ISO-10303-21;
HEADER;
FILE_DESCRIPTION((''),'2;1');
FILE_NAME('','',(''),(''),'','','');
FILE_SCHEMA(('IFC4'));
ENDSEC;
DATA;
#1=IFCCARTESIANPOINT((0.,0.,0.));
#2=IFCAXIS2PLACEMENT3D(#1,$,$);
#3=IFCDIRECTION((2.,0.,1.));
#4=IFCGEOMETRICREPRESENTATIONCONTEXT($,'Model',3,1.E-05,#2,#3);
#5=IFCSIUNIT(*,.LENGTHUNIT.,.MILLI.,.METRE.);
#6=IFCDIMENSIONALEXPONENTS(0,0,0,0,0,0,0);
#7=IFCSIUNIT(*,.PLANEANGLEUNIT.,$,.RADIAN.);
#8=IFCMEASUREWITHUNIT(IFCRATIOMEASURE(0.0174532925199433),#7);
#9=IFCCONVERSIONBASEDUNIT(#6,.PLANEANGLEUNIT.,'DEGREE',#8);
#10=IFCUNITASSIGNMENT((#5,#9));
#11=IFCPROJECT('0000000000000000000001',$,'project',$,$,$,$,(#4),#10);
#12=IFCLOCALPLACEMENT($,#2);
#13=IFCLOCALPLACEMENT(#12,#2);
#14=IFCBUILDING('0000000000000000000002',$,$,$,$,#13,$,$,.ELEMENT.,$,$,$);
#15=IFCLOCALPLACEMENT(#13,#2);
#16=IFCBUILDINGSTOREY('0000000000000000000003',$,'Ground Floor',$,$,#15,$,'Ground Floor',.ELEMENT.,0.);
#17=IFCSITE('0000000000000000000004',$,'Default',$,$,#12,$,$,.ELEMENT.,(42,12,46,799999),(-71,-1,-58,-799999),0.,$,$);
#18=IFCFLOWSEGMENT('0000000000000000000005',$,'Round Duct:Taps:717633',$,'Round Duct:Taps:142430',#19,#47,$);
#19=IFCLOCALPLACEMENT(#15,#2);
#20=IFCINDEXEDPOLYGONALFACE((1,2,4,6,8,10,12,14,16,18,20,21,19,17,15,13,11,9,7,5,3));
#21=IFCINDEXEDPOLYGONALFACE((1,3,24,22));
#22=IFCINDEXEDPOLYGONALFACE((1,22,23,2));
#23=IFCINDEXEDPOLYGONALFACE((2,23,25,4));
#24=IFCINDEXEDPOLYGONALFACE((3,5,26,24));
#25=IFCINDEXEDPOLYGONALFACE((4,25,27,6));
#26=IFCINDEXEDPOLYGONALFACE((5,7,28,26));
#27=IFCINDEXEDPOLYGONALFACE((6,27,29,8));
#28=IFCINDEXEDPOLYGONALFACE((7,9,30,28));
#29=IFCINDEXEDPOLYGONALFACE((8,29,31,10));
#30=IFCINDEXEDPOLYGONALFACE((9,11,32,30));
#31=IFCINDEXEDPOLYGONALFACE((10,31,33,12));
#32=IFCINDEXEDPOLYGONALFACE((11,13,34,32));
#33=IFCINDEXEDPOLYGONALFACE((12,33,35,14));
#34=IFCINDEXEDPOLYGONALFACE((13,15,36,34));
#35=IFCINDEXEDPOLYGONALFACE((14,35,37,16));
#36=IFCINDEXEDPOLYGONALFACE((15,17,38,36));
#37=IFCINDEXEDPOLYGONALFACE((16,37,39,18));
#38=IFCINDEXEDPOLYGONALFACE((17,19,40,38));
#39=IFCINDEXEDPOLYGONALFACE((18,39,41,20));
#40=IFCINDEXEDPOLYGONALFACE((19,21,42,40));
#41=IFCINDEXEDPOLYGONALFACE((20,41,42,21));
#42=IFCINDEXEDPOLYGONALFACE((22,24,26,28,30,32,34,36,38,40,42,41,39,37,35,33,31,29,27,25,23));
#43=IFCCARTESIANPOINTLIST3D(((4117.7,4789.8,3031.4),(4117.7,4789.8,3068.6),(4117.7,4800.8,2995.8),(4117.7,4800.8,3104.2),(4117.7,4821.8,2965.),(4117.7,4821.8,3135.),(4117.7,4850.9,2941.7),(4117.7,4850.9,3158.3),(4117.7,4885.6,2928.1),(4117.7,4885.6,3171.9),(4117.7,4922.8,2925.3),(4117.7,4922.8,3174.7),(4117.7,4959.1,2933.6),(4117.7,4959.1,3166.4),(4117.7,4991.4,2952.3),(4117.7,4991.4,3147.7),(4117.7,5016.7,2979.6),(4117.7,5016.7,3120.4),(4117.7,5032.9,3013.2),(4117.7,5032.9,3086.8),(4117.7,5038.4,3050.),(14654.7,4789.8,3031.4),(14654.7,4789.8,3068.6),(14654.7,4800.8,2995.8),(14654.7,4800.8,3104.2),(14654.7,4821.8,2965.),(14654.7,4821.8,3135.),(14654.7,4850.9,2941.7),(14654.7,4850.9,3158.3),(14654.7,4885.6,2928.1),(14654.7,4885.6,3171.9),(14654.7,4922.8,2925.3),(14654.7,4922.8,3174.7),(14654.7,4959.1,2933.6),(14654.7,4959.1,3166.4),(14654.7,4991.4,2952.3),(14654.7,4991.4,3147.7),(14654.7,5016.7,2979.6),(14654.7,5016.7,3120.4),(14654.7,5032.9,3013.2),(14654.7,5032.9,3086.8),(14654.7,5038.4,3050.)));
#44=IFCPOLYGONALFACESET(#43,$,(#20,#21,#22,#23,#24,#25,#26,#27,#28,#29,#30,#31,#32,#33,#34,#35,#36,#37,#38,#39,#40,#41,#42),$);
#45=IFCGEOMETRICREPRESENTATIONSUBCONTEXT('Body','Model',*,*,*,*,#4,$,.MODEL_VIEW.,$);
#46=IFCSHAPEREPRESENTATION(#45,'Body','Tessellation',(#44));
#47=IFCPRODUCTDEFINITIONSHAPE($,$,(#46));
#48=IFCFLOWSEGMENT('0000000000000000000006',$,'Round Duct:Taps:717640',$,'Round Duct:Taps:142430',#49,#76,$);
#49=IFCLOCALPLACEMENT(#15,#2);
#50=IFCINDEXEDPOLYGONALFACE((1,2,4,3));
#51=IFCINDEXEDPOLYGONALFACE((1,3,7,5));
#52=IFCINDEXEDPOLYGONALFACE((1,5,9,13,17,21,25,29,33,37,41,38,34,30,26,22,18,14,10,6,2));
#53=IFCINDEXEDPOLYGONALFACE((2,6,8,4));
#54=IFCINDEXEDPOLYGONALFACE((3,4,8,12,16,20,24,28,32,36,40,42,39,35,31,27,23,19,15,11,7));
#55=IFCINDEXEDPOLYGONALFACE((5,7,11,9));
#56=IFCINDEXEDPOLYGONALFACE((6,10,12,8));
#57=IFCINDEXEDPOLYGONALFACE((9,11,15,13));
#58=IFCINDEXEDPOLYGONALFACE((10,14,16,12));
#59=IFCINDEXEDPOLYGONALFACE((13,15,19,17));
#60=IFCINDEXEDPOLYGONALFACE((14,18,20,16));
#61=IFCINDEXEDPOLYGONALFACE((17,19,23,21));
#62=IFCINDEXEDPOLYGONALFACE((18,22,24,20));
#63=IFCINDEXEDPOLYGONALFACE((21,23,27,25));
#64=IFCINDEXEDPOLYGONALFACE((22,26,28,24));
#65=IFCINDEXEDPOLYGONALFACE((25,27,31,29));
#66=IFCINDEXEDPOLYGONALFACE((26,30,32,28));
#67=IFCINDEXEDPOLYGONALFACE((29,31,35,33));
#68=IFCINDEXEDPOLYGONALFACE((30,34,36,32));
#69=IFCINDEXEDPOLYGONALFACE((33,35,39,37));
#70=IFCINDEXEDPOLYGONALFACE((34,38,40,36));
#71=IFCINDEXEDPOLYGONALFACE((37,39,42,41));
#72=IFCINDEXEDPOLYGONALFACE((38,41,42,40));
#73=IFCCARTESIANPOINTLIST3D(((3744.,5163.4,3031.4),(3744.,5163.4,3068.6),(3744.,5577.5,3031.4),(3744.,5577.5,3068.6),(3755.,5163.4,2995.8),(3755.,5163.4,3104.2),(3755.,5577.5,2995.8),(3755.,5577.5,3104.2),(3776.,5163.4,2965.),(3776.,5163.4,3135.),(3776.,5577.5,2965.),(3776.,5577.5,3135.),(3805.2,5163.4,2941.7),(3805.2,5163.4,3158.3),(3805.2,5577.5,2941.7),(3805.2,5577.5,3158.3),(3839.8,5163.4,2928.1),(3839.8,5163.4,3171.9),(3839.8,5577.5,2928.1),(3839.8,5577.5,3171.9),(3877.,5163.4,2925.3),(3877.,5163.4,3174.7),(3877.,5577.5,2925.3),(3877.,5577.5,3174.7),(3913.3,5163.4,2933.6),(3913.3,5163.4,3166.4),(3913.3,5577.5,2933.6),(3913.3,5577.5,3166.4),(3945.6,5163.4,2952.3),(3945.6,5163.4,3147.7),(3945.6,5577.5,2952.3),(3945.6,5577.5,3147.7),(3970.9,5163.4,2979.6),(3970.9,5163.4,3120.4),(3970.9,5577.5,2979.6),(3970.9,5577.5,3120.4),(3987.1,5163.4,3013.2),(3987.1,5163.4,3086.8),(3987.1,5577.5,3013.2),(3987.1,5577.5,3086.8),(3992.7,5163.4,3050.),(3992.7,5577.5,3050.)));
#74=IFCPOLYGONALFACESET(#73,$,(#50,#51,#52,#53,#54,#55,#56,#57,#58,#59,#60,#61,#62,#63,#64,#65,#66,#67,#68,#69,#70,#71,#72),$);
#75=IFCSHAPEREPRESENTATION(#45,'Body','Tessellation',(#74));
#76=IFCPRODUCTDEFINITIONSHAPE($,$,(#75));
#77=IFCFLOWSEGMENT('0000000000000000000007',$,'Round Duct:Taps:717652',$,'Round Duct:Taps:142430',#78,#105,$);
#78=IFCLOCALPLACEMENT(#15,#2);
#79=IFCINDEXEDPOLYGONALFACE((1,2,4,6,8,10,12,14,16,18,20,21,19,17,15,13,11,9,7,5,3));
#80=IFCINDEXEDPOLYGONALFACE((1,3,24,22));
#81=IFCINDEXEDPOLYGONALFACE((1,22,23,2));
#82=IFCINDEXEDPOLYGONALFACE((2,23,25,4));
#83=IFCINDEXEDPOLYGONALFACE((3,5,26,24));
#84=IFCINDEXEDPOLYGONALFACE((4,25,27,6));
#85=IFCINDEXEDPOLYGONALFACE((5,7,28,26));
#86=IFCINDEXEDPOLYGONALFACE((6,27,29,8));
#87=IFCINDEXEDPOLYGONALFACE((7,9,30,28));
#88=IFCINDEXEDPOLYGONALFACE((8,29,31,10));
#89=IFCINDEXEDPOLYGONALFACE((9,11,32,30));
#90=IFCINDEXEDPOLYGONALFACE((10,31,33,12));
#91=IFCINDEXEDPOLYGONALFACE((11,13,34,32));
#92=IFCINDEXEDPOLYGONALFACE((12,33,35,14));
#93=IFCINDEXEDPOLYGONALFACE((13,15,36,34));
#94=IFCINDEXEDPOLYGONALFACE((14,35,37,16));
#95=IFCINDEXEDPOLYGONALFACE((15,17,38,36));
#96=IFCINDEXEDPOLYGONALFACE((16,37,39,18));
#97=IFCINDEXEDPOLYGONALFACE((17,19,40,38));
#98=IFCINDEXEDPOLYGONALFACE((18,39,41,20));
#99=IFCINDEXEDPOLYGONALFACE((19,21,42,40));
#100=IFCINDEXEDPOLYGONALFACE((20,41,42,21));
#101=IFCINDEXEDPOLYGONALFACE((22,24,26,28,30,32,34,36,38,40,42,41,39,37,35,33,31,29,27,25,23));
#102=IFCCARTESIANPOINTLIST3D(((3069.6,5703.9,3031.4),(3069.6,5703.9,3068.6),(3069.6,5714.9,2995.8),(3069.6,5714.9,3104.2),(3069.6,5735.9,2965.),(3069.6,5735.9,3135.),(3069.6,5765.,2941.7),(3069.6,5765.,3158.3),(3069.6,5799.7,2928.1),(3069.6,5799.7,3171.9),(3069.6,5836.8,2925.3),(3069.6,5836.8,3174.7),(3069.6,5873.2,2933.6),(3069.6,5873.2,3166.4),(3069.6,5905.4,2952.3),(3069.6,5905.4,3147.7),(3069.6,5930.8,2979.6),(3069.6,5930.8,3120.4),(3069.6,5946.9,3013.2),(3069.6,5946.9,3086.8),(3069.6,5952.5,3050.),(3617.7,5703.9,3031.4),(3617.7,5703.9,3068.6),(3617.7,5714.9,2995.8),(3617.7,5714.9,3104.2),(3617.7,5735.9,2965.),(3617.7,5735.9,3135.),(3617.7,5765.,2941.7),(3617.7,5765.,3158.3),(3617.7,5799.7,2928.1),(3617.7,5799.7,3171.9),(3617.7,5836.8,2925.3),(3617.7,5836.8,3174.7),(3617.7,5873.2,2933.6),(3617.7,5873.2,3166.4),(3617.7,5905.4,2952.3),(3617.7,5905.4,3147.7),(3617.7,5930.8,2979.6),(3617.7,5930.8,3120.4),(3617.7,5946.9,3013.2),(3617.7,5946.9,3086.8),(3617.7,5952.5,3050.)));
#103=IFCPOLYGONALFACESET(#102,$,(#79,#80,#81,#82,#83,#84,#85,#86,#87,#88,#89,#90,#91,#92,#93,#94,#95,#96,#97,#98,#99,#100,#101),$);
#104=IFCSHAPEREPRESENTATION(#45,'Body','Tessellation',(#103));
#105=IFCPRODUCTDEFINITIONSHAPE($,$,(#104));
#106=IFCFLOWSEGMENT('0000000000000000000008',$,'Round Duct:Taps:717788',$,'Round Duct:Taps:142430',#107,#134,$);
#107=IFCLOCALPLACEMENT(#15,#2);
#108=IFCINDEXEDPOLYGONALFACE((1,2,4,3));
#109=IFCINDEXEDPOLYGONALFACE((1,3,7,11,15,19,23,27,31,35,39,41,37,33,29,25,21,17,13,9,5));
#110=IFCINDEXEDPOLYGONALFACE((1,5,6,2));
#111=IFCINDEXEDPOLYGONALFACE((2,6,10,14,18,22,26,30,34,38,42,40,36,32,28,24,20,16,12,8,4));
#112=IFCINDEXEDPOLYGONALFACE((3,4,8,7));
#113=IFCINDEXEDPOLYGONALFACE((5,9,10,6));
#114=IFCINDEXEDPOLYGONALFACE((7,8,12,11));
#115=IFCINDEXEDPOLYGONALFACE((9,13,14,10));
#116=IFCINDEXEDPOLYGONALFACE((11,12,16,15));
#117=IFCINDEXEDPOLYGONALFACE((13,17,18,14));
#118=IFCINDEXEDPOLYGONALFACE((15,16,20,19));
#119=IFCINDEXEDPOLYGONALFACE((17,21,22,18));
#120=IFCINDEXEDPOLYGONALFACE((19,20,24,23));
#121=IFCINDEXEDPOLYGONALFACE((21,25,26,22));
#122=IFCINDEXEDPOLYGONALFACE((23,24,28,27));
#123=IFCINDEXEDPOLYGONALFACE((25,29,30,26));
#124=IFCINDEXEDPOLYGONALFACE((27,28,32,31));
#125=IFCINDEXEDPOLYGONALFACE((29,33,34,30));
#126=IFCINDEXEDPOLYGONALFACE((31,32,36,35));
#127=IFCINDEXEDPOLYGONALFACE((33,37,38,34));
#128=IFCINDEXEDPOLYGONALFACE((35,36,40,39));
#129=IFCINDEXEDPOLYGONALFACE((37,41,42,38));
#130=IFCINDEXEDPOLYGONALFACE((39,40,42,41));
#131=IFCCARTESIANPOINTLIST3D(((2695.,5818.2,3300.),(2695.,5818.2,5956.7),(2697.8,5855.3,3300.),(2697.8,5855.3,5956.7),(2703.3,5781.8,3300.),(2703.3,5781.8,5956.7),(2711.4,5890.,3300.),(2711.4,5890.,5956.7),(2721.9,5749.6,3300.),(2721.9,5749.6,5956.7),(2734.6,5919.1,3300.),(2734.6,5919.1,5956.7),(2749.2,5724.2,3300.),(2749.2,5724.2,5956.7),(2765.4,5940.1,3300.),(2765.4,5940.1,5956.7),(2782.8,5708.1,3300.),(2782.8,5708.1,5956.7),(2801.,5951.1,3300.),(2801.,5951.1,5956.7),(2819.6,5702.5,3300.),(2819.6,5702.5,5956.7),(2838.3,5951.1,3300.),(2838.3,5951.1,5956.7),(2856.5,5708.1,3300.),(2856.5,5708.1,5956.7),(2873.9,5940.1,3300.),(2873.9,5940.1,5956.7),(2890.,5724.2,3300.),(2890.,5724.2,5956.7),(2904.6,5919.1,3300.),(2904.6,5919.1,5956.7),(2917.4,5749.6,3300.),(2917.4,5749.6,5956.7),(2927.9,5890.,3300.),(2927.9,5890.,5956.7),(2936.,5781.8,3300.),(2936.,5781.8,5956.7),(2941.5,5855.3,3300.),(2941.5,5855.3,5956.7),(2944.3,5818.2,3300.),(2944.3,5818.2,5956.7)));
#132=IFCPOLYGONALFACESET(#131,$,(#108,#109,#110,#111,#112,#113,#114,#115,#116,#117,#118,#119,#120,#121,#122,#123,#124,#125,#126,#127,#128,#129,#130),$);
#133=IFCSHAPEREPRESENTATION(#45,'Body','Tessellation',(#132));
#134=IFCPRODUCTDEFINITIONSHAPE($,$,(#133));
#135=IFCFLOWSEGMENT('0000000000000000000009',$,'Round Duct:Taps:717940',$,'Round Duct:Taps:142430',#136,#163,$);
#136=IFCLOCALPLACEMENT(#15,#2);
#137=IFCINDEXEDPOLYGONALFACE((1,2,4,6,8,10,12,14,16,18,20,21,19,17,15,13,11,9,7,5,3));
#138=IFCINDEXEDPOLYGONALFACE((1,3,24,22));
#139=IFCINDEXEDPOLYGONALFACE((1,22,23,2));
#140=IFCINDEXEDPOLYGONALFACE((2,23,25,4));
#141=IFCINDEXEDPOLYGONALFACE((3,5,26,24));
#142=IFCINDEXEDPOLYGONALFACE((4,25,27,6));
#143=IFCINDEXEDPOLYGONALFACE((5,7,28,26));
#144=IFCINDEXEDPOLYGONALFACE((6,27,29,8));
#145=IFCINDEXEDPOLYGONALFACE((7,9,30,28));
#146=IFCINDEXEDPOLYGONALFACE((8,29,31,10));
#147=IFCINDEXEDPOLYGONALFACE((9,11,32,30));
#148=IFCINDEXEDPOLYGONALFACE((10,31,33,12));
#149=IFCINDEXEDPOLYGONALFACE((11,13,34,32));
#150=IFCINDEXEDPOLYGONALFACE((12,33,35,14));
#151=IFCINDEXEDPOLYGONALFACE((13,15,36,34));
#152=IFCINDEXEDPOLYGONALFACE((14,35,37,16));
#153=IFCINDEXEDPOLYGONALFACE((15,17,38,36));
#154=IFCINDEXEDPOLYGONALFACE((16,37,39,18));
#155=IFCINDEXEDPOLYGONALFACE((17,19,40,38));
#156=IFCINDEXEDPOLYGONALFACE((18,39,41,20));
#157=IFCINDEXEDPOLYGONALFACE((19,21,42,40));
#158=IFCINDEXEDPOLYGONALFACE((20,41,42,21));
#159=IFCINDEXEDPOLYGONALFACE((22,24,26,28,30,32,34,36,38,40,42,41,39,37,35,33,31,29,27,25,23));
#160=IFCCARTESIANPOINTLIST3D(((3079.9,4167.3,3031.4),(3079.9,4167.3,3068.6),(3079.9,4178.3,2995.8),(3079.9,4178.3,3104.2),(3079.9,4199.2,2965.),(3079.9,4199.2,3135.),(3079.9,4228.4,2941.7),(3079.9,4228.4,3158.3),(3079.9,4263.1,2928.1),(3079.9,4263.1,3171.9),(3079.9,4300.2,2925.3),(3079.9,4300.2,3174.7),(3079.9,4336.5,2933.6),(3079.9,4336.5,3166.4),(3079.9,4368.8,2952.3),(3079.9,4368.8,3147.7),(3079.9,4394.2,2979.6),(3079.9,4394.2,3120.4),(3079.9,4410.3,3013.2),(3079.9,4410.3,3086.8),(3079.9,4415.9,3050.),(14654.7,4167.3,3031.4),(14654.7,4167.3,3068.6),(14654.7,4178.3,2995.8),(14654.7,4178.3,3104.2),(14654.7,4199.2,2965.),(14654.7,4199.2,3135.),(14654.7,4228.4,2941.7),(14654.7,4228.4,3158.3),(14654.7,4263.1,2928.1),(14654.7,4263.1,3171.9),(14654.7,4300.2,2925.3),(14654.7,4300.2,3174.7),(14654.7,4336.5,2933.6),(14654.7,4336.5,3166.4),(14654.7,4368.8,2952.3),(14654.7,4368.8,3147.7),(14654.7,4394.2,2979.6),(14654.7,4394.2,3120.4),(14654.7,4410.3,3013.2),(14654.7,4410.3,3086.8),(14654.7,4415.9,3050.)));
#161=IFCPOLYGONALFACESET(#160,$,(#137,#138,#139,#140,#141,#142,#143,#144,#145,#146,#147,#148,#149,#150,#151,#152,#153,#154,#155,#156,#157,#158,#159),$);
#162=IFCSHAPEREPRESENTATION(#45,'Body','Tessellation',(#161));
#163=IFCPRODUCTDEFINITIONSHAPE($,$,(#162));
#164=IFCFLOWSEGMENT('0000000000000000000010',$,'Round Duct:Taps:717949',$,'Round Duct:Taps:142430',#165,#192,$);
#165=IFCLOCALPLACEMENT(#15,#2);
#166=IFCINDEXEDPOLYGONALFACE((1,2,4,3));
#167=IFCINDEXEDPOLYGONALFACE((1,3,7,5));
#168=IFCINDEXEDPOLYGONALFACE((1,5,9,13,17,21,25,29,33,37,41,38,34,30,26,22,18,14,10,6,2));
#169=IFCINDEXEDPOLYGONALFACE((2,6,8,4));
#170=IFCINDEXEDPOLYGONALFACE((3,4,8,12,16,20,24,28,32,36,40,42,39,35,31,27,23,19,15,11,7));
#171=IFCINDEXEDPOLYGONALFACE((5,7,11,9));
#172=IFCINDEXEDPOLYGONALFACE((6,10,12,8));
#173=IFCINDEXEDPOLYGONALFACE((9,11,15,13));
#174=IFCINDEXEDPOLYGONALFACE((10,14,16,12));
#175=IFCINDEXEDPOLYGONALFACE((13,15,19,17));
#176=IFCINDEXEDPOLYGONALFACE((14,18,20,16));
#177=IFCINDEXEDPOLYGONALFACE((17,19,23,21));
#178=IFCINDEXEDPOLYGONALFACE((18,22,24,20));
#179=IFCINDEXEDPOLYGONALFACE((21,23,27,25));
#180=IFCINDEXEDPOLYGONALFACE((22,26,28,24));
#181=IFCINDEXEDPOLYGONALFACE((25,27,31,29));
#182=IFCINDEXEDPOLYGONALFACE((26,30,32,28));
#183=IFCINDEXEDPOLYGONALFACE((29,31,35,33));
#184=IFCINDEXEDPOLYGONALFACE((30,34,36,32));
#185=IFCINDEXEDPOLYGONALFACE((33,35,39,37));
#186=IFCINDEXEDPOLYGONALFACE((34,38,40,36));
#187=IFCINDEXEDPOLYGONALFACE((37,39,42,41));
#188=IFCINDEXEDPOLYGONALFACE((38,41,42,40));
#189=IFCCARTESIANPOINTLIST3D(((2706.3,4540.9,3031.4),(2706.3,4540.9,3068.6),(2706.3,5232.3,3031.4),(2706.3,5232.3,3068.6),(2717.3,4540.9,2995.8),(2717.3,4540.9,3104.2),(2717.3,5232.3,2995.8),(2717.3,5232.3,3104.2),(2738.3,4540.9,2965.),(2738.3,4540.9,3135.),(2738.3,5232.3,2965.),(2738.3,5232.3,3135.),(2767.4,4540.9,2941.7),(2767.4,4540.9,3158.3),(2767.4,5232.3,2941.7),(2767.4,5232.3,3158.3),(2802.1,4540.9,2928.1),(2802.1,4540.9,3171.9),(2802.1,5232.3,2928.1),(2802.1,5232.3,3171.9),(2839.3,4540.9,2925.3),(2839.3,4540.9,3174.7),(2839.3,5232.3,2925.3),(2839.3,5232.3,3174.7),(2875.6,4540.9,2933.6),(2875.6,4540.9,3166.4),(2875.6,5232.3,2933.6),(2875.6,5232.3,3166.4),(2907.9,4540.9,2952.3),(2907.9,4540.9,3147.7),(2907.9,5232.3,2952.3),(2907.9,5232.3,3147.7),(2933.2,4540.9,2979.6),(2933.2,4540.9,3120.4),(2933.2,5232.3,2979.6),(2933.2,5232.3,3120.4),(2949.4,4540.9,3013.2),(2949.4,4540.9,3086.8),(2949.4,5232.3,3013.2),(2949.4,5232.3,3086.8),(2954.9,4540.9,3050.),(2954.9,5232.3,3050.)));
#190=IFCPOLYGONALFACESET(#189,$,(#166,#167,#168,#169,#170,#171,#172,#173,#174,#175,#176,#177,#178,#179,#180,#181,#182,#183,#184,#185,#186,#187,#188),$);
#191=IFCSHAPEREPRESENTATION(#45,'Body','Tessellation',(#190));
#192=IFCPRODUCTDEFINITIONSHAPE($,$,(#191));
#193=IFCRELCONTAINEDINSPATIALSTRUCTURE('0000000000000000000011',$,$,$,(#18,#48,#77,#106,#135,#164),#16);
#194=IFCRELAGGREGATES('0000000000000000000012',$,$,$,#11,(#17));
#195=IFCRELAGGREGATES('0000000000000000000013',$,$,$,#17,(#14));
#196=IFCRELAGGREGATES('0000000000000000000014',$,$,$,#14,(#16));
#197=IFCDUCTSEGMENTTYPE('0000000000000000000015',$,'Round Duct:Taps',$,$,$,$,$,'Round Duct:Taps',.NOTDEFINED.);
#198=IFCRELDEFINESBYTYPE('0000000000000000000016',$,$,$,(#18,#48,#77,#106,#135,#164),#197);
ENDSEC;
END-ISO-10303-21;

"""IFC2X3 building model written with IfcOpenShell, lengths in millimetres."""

from ifc_helpers import new_model, entity, si_unit, converted_unit, direction, frame, frame_2d, origin, origin_2d_with_axis, place, context, subcontext, project, spatial, circle, extrude, type_object, element, save


model = new_model("IFC2X3")

# Units and contexts
model_context = context("Model", 3, precision=1e-05, world=origin(), true_north=direction((2.0, 0.0, 1.0)))
body_context = subcontext(model_context, "Body", "Model", "MODEL_VIEW")
ifc_project = project(units=[si_unit("LENGTHUNIT", "METRE", prefix="MILLI"), converted_unit("PLANEANGLEUNIT", "DEGREE", entity("IfcRatioMeasure", 0.0174532925199433), si_unit("PLANEANGLEUNIT", "RADIAN"), dimensions=[0, 0, 0, 0, 0, 0, 0])], contexts=[model_context])

# Site, building, storey
site_placement = place(None, origin())
site = spatial("IfcSite", under=ifc_project, at=site_placement, Name="Default", CompositionType="ELEMENT", RefLatitude=(42, 12, 46, 799999), RefLongitude=(-71, -1, -58, -799999), RefElevation=0.0)
building_placement = place(site_placement, origin())
building = spatial("IfcBuilding", under=site, at=building_placement, CompositionType="ELEMENT")
storey_placement = place(building_placement, origin())
storey = spatial("IfcBuildingStorey", under=building, at=storey_placement, Name="Ground Floor", LongName="Ground Floor", CompositionType="ELEMENT", Elevation=0.0)

# Flow segments
duct_segment_type_1 = type_object("IfcDuctSegmentType", Name="Round Duct:Taps", ElementType="Round Duct:Taps", PredefinedType="NOTDEFINED")
flow_segment_1_placement = place(storey_placement, origin())
element("IfcFlowSegment", 1, at=flow_segment_1_placement, inside=storey, type_object=duct_segment_type_1, Name="Round Duct:Taps:717633", ObjectType="Round Duct:Taps:142430", context=body_context, shape_type="SweptSolid", body=[
    extrude(circle(Radius=125.0, at=frame_2d((0.0, 0.0), x_axis=(1.0, 0.0))), frame((4117.7, 4913.4, 3050.0), z_axis=(1.0, 0.0, 0.0), x_axis=(0.0, 1.0, 0.0)), (0.0, 0.0, 1.0), 10537.0),
])
flow_segment_2_placement = place(storey_placement, origin())
element("IfcFlowSegment", 2, at=flow_segment_2_placement, inside=storey, type_object=duct_segment_type_1, Name="Round Duct:Taps:717640", ObjectType="Round Duct:Taps:142430", context=body_context, shape_type="SweptSolid", body=[
    extrude(circle(Radius=125.0, at=frame_2d((0.0, 0.0), x_axis=(1.0, 0.0))), frame((3867.7, 5163.4, 3050.0), z_axis=(0.0, 1.0, 0.0), x_axis=(1.0, 0.0, 0.0)), (0.0, 0.0, 1.0), 414.1),
])
flow_segment_3_placement = place(storey_placement, origin())
element("IfcFlowSegment", 3, at=flow_segment_3_placement, inside=storey, type_object=duct_segment_type_1, Name="Round Duct:Taps:717652", ObjectType="Round Duct:Taps:142430", context=body_context, shape_type="SweptSolid", body=[
    extrude(circle(Radius=125.0, at=frame_2d((0.0, 0.0), x_axis=(1.0, 0.0))), frame((3069.6, 5827.5, 3050.0), z_axis=(1.0, 0.0, 0.0), x_axis=(0.0, 1.0, 0.0)), (0.0, 0.0, 1.0), 548.0),
])
flow_segment_4_placement = place(storey_placement, origin())
element("IfcFlowSegment", 4, at=flow_segment_4_placement, inside=storey, type_object=duct_segment_type_1, Name="Round Duct:Taps:717788", ObjectType="Round Duct:Taps:142430", context=body_context, shape_type="SweptSolid", body=[
    extrude(circle(Radius=125.0, at=frame_2d((0.0, 0.0), x_axis=(1.0, 0.0))), frame((2819.6, 5827.5, 3300.0), z_axis=(0.0, 0.0, 1.0), x_axis=(0.0, -1.0, 0.0)), (0.0, 0.0, 1.0), 2656.7),
])
flow_segment_5_placement = place(storey_placement, origin())
element("IfcFlowSegment", 5, at=flow_segment_5_placement, inside=storey, type_object=duct_segment_type_1, Name="Round Duct:Taps:717940", ObjectType="Round Duct:Taps:142430", context=body_context, shape_type="SweptSolid", body=[
    extrude(circle(Radius=125.0, at=frame_2d((0.0, 0.0), x_axis=(1.0, 0.0))), frame((3079.9, 4290.9, 3050.0), z_axis=(1.0, 0.0, 0.0), x_axis=(0.0, 1.0, 0.0)), (0.0, 0.0, 1.0), 11574.7),
])
flow_segment_6_placement = place(storey_placement, origin())
element("IfcFlowSegment", 6, at=flow_segment_6_placement, inside=storey, type_object=duct_segment_type_1, Name="Round Duct:Taps:717949", ObjectType="Round Duct:Taps:142430", context=body_context, shape_type="SweptSolid", body=[
    extrude(circle(Radius=125.0, at=origin_2d_with_axis()), frame((2829.9, 4540.9, 3050.0), z_axis=(0.0, 1.0, 0.0), x_axis=(1.0, 0.0, 0.0)), (0.0, 0.0, 1.0), 691.5),
])

save(model, "model.ifc")
